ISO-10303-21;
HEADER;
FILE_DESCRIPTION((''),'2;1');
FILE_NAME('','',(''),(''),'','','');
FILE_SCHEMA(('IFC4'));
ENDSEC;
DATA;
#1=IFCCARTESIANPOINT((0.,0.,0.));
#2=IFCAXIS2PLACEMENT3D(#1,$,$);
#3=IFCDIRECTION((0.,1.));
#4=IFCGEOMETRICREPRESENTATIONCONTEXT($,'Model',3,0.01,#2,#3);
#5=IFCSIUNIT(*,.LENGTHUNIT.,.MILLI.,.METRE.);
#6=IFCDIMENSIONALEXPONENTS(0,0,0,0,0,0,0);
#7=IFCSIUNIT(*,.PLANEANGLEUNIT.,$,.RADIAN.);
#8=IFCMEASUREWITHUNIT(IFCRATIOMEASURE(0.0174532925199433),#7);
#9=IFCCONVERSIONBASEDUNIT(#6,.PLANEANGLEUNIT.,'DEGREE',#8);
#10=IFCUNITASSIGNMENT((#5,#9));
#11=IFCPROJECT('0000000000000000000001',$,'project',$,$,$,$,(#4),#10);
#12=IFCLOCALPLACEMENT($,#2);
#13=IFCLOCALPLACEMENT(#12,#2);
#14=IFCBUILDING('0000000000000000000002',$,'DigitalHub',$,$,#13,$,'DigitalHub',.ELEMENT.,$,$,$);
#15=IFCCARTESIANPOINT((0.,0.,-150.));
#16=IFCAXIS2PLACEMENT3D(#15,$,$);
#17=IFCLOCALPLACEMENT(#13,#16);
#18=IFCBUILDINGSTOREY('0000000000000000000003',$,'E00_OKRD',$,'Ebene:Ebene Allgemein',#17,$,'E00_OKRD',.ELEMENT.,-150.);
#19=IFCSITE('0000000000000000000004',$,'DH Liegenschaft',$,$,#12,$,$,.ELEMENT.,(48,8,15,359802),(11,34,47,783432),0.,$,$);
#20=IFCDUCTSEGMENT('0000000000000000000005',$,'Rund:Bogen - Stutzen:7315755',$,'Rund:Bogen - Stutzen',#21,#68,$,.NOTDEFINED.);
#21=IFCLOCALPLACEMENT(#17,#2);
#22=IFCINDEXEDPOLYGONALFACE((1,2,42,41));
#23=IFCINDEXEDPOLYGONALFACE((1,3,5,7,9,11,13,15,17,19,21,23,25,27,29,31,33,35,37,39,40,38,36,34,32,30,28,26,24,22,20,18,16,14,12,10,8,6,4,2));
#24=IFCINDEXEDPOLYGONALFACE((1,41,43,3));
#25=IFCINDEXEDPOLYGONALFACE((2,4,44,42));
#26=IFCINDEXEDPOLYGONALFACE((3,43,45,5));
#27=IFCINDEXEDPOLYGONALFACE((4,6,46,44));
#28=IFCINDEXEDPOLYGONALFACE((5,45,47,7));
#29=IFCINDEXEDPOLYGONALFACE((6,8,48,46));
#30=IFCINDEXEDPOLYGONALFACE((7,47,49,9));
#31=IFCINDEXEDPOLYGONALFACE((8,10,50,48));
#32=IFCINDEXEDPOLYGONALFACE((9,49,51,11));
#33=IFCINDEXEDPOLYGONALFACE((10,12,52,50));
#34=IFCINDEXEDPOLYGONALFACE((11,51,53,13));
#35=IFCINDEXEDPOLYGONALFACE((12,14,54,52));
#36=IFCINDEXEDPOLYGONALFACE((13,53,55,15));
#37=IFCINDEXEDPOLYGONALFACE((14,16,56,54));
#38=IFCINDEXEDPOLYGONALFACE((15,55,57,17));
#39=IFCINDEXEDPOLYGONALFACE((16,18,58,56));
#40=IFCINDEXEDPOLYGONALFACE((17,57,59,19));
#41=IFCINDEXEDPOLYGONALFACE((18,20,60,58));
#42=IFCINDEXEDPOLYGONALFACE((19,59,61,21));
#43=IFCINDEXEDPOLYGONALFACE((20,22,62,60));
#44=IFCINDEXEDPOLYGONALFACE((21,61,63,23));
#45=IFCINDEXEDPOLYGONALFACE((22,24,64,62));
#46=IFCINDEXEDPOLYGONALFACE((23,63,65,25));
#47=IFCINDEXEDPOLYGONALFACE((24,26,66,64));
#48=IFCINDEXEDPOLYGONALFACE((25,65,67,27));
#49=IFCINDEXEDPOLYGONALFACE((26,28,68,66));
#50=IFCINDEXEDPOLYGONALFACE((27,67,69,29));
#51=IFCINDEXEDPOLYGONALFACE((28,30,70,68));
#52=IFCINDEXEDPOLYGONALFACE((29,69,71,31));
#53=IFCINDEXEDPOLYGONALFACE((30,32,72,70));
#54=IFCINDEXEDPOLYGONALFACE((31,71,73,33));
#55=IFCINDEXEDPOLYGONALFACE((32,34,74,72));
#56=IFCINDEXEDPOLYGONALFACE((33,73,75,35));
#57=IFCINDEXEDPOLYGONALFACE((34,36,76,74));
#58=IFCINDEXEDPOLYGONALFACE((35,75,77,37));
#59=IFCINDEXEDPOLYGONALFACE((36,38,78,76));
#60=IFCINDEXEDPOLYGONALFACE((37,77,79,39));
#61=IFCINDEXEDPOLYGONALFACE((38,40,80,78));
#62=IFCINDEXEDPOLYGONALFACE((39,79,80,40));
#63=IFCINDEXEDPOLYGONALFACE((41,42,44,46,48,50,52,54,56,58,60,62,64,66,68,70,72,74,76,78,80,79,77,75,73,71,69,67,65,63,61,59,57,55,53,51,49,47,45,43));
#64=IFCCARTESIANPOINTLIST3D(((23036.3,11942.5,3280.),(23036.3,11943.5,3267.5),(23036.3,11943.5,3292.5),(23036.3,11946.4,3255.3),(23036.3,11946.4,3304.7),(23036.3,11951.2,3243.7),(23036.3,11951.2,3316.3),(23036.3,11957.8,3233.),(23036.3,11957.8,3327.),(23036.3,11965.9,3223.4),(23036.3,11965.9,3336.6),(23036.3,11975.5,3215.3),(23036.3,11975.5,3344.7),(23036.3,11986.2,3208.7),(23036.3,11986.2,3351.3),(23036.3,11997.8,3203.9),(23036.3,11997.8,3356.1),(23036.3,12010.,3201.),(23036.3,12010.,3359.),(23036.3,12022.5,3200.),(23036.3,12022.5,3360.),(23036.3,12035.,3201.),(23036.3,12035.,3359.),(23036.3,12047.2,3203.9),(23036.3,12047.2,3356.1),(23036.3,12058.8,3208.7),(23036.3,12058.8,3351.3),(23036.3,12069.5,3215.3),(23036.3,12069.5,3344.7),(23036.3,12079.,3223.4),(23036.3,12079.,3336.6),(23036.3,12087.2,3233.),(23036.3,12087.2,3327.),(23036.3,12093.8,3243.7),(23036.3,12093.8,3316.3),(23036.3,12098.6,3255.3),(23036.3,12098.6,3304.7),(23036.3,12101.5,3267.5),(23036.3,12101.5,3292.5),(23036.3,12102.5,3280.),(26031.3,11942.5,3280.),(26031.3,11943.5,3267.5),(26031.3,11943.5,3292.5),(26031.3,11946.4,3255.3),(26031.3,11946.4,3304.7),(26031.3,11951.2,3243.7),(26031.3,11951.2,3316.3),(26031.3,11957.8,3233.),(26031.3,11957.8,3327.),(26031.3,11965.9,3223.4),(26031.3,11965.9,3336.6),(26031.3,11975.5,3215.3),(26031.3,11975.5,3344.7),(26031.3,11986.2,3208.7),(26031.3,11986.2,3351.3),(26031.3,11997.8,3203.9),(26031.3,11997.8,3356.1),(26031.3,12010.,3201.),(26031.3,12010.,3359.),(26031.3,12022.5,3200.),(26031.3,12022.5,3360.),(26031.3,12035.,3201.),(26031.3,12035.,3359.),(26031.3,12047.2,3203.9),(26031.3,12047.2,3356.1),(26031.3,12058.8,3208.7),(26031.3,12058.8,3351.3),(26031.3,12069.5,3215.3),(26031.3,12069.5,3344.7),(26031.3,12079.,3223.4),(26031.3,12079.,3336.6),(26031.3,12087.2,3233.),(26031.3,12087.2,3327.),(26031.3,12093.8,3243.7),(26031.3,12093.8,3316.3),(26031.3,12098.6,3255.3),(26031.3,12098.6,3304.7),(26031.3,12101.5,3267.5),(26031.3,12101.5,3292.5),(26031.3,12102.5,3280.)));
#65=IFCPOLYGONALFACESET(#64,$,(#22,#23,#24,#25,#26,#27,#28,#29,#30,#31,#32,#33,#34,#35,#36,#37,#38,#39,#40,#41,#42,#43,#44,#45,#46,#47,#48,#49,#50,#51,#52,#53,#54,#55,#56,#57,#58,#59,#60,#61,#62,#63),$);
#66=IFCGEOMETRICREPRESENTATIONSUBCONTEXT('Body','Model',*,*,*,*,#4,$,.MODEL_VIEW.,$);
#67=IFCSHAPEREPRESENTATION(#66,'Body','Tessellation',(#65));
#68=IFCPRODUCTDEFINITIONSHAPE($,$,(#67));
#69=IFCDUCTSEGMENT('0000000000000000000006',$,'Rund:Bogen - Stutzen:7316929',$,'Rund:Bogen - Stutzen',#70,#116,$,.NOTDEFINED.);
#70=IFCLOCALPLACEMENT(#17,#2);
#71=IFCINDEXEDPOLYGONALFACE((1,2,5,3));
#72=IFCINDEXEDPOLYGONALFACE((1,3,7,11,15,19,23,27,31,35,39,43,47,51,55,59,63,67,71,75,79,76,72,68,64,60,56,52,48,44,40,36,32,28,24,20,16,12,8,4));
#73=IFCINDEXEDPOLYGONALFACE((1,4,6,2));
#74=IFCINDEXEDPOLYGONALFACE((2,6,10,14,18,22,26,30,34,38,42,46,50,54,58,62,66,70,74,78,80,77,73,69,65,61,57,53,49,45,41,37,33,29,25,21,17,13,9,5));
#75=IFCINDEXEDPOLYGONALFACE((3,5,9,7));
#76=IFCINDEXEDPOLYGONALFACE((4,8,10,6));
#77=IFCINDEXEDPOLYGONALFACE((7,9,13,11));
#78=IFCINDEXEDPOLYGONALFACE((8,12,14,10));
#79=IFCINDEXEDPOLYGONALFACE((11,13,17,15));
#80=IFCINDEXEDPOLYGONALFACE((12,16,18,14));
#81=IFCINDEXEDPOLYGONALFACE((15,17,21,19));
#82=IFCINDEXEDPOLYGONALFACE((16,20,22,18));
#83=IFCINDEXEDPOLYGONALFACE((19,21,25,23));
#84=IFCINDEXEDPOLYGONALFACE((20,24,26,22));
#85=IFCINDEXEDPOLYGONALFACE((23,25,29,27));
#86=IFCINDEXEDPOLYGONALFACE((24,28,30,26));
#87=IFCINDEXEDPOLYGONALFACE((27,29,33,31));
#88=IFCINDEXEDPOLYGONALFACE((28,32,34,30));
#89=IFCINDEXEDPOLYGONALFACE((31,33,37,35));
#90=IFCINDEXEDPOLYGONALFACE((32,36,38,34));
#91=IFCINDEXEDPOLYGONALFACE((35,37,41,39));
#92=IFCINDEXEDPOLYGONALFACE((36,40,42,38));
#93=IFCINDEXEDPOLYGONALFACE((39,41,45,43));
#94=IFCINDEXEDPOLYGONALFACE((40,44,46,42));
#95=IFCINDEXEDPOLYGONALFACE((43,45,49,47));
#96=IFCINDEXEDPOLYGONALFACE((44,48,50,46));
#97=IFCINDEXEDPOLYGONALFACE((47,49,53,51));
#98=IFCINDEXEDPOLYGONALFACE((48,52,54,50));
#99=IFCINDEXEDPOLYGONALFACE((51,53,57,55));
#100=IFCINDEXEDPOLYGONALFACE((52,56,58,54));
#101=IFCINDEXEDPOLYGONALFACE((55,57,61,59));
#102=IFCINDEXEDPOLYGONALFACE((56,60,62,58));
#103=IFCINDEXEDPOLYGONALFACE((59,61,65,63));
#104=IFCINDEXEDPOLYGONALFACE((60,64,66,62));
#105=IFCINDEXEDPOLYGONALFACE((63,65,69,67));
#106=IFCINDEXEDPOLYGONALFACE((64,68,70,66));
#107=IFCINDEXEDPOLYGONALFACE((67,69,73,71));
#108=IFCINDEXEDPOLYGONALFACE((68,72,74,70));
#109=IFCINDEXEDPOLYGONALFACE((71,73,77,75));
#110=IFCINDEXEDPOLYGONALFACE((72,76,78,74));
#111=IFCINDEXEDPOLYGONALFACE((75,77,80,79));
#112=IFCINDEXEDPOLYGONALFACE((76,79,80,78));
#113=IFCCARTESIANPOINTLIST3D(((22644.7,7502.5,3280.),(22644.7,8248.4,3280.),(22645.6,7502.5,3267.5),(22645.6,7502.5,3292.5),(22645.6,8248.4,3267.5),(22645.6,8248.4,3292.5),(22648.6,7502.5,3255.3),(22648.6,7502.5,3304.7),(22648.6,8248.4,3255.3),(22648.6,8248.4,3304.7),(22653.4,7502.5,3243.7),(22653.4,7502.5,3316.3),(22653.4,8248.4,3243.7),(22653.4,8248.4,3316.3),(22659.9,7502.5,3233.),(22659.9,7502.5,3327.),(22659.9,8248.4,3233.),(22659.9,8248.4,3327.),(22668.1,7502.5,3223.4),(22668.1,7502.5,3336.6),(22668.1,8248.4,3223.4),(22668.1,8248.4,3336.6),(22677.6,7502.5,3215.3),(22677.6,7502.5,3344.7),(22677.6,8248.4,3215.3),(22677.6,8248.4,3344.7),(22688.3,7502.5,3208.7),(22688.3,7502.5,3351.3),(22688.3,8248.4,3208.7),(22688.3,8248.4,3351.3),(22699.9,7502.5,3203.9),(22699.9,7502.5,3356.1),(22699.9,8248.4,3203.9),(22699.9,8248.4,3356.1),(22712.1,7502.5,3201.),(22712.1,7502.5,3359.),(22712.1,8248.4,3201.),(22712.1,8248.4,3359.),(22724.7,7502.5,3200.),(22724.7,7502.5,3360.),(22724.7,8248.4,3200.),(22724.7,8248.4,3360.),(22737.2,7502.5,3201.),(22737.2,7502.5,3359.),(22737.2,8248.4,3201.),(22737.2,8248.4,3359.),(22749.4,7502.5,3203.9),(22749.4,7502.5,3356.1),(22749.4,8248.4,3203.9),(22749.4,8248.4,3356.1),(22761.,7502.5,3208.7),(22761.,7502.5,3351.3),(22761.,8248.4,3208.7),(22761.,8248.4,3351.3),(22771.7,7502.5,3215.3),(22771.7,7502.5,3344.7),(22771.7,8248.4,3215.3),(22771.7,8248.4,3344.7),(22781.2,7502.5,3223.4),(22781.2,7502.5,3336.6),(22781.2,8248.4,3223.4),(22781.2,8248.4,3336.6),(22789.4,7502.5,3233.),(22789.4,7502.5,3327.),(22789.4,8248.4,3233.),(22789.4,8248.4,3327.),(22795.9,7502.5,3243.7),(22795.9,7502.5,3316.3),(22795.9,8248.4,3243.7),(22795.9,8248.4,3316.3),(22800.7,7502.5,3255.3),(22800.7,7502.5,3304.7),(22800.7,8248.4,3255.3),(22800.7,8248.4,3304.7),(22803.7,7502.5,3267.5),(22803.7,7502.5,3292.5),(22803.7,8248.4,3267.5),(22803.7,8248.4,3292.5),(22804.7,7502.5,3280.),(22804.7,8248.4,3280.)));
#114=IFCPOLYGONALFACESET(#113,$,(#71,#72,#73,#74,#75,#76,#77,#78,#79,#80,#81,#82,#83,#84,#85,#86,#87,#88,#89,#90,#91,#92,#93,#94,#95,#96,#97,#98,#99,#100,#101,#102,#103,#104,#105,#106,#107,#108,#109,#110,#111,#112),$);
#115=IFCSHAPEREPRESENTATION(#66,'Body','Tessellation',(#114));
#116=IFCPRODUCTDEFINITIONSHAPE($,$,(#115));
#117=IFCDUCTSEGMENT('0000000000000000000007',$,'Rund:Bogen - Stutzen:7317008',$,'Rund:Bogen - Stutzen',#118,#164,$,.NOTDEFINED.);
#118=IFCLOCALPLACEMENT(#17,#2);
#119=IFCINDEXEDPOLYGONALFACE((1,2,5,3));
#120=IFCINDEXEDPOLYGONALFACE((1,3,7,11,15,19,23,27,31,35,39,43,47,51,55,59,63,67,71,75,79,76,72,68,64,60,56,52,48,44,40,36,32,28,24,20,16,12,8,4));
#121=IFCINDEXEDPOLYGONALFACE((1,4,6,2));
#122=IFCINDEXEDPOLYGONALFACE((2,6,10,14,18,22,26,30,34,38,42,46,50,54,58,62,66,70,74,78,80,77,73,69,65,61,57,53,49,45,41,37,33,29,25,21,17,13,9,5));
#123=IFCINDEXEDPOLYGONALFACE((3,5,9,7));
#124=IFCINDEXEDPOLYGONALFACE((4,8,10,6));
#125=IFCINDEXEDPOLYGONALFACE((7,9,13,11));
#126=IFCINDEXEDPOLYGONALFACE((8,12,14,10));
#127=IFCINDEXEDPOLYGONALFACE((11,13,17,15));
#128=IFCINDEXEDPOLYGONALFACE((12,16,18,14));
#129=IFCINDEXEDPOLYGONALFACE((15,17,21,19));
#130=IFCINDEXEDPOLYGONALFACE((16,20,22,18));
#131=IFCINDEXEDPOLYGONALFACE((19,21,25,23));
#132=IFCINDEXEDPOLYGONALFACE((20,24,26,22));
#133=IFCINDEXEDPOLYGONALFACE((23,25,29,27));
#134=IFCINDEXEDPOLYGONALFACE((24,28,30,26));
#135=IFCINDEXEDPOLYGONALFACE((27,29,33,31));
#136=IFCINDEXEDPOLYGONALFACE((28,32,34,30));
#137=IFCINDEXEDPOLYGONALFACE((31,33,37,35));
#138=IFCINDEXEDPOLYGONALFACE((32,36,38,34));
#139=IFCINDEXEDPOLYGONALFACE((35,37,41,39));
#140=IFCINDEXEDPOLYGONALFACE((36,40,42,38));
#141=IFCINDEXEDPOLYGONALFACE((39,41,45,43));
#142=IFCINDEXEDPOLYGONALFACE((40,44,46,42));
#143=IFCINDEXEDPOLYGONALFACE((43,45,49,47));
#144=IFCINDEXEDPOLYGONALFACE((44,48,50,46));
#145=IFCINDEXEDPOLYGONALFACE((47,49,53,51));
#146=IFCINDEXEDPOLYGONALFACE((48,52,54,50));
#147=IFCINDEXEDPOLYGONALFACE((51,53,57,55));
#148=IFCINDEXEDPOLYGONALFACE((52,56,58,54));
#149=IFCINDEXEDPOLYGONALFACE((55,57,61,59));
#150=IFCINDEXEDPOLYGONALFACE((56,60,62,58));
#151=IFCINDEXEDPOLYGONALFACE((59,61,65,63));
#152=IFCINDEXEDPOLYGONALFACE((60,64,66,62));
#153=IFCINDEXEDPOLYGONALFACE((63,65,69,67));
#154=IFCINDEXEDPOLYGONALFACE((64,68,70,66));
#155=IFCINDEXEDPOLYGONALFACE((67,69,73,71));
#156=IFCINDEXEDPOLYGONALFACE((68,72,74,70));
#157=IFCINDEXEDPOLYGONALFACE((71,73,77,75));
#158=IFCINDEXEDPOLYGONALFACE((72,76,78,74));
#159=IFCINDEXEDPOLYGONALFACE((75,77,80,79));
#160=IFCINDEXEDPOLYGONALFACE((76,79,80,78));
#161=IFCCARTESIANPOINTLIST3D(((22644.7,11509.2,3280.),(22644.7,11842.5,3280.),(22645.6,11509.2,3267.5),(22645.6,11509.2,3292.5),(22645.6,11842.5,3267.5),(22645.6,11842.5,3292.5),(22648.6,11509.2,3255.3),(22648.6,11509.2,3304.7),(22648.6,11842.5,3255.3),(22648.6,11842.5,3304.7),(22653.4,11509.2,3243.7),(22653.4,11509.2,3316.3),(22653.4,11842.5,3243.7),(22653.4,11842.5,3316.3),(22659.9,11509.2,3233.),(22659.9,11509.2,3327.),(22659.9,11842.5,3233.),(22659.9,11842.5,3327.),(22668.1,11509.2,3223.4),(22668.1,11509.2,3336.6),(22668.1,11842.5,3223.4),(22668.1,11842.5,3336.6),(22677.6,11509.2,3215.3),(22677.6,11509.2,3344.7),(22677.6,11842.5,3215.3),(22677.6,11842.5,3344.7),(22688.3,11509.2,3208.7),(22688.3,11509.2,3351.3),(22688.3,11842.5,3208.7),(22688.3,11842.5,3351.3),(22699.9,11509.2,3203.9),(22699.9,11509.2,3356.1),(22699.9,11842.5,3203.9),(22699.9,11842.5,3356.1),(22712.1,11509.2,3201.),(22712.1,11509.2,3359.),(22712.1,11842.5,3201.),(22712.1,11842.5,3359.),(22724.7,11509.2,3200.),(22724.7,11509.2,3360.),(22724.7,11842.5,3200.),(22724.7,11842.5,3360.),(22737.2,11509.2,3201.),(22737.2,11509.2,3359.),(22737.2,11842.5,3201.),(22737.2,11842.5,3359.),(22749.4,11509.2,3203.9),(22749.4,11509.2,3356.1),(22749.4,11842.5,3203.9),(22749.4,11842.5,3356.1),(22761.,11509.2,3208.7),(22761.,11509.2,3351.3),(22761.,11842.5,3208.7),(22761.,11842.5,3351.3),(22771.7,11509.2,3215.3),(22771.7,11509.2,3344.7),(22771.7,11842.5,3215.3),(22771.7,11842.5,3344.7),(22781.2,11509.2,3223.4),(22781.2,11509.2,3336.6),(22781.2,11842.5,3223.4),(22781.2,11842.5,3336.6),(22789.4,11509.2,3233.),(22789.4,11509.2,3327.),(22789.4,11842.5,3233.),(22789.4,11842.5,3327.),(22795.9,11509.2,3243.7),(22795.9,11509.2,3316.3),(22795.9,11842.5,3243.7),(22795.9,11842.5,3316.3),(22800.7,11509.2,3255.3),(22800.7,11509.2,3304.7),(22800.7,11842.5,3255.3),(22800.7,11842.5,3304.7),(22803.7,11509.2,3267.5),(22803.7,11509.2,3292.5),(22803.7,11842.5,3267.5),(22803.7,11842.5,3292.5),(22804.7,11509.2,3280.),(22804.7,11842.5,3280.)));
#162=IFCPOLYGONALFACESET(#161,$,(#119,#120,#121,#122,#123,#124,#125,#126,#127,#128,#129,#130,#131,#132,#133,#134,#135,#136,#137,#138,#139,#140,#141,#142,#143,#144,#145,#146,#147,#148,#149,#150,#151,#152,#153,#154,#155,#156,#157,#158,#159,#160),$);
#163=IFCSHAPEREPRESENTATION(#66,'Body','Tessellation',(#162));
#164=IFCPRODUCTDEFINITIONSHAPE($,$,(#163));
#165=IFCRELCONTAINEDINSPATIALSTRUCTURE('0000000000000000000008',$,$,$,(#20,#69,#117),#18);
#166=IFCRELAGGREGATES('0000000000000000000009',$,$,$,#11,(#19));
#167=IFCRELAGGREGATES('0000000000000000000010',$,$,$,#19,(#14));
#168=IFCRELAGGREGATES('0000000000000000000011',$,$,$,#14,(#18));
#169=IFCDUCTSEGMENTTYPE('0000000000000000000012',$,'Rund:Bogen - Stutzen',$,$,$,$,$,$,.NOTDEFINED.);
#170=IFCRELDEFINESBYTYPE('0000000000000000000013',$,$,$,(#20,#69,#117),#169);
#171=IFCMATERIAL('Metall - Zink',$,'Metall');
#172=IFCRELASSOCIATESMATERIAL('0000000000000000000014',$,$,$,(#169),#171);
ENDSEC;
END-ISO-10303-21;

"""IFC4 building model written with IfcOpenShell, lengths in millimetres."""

from ifc_helpers import new_model, entity, si_unit, converted_unit, direction, frame, origin, place, context, subcontext, project, spatial, indexed_curve, outline, extrude, material, type_object, element, save


model = new_model("IFC4")

# Units and contexts
model_context = context("Model", 3, precision=0.01, world=origin(), true_north=direction((0.0, 1.0)))
body_context = subcontext(model_context, "Body", "Model", "MODEL_VIEW")
ifc_project = project(units=[si_unit("LENGTHUNIT", "METRE", prefix="MILLI"), converted_unit("PLANEANGLEUNIT", "DEGREE", entity("IfcRatioMeasure", 0.0174532925199433), si_unit("PLANEANGLEUNIT", "RADIAN"), dimensions=[0, 0, 0, 0, 0, 0, 0])], contexts=[model_context])

# Site, building, storey
site_placement = place(None, origin())
site = spatial("IfcSite", under=ifc_project, at=site_placement, Name="DH Liegenschaft", CompositionType="ELEMENT", RefLatitude=(48, 8, 15, 359802), RefLongitude=(11, 34, 47, 783432), RefElevation=0.0)
building_placement = place(site_placement, origin())
building = spatial("IfcBuilding", under=site, at=building_placement, Name="DigitalHub", LongName="DigitalHub", CompositionType="ELEMENT")
storey_placement = place(building_placement, frame((0.0, 0.0, -150.0)))
storey = spatial("IfcBuildingStorey", under=building, at=storey_placement, Name="E00_OKRD", ObjectType="Ebene:Ebene Allgemein", LongName="E00_OKRD", CompositionType="ELEMENT", Elevation=-150.0)

# Duct segments
ifc_material_1 = material(Name="Metall - Zink", Category="Metall")
duct_segment_type_1 = type_object("IfcDuctSegmentType", Name="Rund:Bogen - Stutzen", PredefinedType="NOTDEFINED", material=ifc_material_1)
duct_segment_1_placement = place(storey_placement, frame((23036.3, 11940.9, 3198.4)))
element("IfcDuctSegment", 1, at=duct_segment_1_placement, inside=storey, type_object=duct_segment_type_1, Name="Rund:Bogen - Stutzen:7315755", ObjectType="Rund:Bogen - Stutzen", PredefinedType="NOTDEFINED", context=body_context, shape_type="SweptSolid", body=[
    extrude(outline(indexed_curve([(80.0, 0.0), (79.0, 12.5), (76.1, 24.7), (71.3, 36.3), (64.7, 47.0), (56.6, 56.6), (47.0, 64.7), (36.3, 71.3), (24.7, 76.1), (12.5, 79.0), (0.0, 80.0), (-12.5, 79.0), (-24.7, 76.1), (-36.3, 71.3), (-47.0, 64.7), (-56.6, 56.6), (-64.7, 47.0), (-71.3, 36.3), (-76.1, 24.7), (-79.0, 12.5), (-80.0, 0.0), (-79.0, -12.5), (-76.1, -24.7), (-71.3, -36.3), (-64.7, -47.0), (-56.6, -56.6), (-47.0, -64.7), (-36.3, -71.3), (-24.7, -76.1), (-12.5, -79.0), (0.0, -80.0), (12.5, -79.0), (24.7, -76.1), (36.3, -71.3), (47.0, -64.7), (56.6, -56.6), (64.7, -47.0), (71.3, -36.3), (76.1, -24.7), (79.0, -12.5), (80.0, 0.0)], self_intersect=False)), frame((0.0, 81.6, 81.6), z_axis=(1.0, 0.0, 0.0), x_axis=(0.0, 1.0, 0.0)), (0.0, 0.0, 1.0), 2995.0),
])
duct_segment_2_placement = place(storey_placement, frame((22643.1, 7502.5, 3198.4)))
element("IfcDuctSegment", 2, at=duct_segment_2_placement, inside=storey, type_object=duct_segment_type_1, Name="Rund:Bogen - Stutzen:7316929", ObjectType="Rund:Bogen - Stutzen", PredefinedType="NOTDEFINED", context=body_context, shape_type="SweptSolid", body=[
    extrude(outline(indexed_curve([(80.0, 0.0), (79.0, 12.5), (76.1, 24.7), (71.3, 36.3), (64.7, 47.0), (56.6, 56.6), (47.0, 64.7), (36.3, 71.3), (24.7, 76.1), (12.5, 79.0), (0.0, 80.0), (-12.5, 79.0), (-24.7, 76.1), (-36.3, 71.3), (-47.0, 64.7), (-56.6, 56.6), (-64.7, 47.0), (-71.3, 36.3), (-76.1, 24.7), (-79.0, 12.5), (-80.0, 0.0), (-79.0, -12.5), (-76.1, -24.7), (-71.3, -36.3), (-64.7, -47.0), (-56.6, -56.6), (-47.0, -64.7), (-36.3, -71.3), (-24.7, -76.1), (-12.5, -79.0), (0.0, -80.0), (12.5, -79.0), (24.7, -76.1), (36.3, -71.3), (47.0, -64.7), (56.6, -56.6), (64.7, -47.0), (71.3, -36.3), (76.1, -24.7), (79.0, -12.5), (80.0, 0.0)], self_intersect=False)), frame((81.6, 0.0, 81.6), z_axis=(0.0, 1.0, 0.0), x_axis=(-1.0, 0.0, 0.0)), (0.0, 0.0, 1.0), 745.9),
])
duct_segment_3_placement = place(storey_placement, frame((22643.1, 11509.2, 3198.4)))
element("IfcDuctSegment", 3, at=duct_segment_3_placement, inside=storey, type_object=duct_segment_type_1, Name="Rund:Bogen - Stutzen:7317008", ObjectType="Rund:Bogen - Stutzen", PredefinedType="NOTDEFINED", context=body_context, shape_type="SweptSolid", body=[
    extrude(outline(indexed_curve([(80.0, 0.0), (79.0, 12.5), (76.1, 24.7), (71.3, 36.3), (64.7, 47.0), (56.6, 56.6), (47.0, 64.7), (36.3, 71.3), (24.7, 76.1), (12.5, 79.0), (0.0, 80.0), (-12.5, 79.0), (-24.7, 76.1), (-36.3, 71.3), (-47.0, 64.7), (-56.6, 56.6), (-64.7, 47.0), (-71.3, 36.3), (-76.1, 24.7), (-79.0, 12.5), (-80.0, 0.0), (-79.0, -12.5), (-76.1, -24.7), (-71.3, -36.3), (-64.7, -47.0), (-56.6, -56.6), (-47.0, -64.7), (-36.3, -71.3), (-24.7, -76.1), (-12.5, -79.0), (0.0, -80.0), (12.5, -79.0), (24.7, -76.1), (36.3, -71.3), (47.0, -64.7), (56.6, -56.6), (64.7, -47.0), (71.3, -36.3), (76.1, -24.7), (79.0, -12.5), (80.0, 0.0)], self_intersect=False)), frame((81.6, 0.0, 81.6), z_axis=(0.0, 1.0, 0.0), x_axis=(-1.0, 0.0, 0.0)), (0.0, 0.0, 1.0), 333.2),
])

save(model, "model.ifc")
